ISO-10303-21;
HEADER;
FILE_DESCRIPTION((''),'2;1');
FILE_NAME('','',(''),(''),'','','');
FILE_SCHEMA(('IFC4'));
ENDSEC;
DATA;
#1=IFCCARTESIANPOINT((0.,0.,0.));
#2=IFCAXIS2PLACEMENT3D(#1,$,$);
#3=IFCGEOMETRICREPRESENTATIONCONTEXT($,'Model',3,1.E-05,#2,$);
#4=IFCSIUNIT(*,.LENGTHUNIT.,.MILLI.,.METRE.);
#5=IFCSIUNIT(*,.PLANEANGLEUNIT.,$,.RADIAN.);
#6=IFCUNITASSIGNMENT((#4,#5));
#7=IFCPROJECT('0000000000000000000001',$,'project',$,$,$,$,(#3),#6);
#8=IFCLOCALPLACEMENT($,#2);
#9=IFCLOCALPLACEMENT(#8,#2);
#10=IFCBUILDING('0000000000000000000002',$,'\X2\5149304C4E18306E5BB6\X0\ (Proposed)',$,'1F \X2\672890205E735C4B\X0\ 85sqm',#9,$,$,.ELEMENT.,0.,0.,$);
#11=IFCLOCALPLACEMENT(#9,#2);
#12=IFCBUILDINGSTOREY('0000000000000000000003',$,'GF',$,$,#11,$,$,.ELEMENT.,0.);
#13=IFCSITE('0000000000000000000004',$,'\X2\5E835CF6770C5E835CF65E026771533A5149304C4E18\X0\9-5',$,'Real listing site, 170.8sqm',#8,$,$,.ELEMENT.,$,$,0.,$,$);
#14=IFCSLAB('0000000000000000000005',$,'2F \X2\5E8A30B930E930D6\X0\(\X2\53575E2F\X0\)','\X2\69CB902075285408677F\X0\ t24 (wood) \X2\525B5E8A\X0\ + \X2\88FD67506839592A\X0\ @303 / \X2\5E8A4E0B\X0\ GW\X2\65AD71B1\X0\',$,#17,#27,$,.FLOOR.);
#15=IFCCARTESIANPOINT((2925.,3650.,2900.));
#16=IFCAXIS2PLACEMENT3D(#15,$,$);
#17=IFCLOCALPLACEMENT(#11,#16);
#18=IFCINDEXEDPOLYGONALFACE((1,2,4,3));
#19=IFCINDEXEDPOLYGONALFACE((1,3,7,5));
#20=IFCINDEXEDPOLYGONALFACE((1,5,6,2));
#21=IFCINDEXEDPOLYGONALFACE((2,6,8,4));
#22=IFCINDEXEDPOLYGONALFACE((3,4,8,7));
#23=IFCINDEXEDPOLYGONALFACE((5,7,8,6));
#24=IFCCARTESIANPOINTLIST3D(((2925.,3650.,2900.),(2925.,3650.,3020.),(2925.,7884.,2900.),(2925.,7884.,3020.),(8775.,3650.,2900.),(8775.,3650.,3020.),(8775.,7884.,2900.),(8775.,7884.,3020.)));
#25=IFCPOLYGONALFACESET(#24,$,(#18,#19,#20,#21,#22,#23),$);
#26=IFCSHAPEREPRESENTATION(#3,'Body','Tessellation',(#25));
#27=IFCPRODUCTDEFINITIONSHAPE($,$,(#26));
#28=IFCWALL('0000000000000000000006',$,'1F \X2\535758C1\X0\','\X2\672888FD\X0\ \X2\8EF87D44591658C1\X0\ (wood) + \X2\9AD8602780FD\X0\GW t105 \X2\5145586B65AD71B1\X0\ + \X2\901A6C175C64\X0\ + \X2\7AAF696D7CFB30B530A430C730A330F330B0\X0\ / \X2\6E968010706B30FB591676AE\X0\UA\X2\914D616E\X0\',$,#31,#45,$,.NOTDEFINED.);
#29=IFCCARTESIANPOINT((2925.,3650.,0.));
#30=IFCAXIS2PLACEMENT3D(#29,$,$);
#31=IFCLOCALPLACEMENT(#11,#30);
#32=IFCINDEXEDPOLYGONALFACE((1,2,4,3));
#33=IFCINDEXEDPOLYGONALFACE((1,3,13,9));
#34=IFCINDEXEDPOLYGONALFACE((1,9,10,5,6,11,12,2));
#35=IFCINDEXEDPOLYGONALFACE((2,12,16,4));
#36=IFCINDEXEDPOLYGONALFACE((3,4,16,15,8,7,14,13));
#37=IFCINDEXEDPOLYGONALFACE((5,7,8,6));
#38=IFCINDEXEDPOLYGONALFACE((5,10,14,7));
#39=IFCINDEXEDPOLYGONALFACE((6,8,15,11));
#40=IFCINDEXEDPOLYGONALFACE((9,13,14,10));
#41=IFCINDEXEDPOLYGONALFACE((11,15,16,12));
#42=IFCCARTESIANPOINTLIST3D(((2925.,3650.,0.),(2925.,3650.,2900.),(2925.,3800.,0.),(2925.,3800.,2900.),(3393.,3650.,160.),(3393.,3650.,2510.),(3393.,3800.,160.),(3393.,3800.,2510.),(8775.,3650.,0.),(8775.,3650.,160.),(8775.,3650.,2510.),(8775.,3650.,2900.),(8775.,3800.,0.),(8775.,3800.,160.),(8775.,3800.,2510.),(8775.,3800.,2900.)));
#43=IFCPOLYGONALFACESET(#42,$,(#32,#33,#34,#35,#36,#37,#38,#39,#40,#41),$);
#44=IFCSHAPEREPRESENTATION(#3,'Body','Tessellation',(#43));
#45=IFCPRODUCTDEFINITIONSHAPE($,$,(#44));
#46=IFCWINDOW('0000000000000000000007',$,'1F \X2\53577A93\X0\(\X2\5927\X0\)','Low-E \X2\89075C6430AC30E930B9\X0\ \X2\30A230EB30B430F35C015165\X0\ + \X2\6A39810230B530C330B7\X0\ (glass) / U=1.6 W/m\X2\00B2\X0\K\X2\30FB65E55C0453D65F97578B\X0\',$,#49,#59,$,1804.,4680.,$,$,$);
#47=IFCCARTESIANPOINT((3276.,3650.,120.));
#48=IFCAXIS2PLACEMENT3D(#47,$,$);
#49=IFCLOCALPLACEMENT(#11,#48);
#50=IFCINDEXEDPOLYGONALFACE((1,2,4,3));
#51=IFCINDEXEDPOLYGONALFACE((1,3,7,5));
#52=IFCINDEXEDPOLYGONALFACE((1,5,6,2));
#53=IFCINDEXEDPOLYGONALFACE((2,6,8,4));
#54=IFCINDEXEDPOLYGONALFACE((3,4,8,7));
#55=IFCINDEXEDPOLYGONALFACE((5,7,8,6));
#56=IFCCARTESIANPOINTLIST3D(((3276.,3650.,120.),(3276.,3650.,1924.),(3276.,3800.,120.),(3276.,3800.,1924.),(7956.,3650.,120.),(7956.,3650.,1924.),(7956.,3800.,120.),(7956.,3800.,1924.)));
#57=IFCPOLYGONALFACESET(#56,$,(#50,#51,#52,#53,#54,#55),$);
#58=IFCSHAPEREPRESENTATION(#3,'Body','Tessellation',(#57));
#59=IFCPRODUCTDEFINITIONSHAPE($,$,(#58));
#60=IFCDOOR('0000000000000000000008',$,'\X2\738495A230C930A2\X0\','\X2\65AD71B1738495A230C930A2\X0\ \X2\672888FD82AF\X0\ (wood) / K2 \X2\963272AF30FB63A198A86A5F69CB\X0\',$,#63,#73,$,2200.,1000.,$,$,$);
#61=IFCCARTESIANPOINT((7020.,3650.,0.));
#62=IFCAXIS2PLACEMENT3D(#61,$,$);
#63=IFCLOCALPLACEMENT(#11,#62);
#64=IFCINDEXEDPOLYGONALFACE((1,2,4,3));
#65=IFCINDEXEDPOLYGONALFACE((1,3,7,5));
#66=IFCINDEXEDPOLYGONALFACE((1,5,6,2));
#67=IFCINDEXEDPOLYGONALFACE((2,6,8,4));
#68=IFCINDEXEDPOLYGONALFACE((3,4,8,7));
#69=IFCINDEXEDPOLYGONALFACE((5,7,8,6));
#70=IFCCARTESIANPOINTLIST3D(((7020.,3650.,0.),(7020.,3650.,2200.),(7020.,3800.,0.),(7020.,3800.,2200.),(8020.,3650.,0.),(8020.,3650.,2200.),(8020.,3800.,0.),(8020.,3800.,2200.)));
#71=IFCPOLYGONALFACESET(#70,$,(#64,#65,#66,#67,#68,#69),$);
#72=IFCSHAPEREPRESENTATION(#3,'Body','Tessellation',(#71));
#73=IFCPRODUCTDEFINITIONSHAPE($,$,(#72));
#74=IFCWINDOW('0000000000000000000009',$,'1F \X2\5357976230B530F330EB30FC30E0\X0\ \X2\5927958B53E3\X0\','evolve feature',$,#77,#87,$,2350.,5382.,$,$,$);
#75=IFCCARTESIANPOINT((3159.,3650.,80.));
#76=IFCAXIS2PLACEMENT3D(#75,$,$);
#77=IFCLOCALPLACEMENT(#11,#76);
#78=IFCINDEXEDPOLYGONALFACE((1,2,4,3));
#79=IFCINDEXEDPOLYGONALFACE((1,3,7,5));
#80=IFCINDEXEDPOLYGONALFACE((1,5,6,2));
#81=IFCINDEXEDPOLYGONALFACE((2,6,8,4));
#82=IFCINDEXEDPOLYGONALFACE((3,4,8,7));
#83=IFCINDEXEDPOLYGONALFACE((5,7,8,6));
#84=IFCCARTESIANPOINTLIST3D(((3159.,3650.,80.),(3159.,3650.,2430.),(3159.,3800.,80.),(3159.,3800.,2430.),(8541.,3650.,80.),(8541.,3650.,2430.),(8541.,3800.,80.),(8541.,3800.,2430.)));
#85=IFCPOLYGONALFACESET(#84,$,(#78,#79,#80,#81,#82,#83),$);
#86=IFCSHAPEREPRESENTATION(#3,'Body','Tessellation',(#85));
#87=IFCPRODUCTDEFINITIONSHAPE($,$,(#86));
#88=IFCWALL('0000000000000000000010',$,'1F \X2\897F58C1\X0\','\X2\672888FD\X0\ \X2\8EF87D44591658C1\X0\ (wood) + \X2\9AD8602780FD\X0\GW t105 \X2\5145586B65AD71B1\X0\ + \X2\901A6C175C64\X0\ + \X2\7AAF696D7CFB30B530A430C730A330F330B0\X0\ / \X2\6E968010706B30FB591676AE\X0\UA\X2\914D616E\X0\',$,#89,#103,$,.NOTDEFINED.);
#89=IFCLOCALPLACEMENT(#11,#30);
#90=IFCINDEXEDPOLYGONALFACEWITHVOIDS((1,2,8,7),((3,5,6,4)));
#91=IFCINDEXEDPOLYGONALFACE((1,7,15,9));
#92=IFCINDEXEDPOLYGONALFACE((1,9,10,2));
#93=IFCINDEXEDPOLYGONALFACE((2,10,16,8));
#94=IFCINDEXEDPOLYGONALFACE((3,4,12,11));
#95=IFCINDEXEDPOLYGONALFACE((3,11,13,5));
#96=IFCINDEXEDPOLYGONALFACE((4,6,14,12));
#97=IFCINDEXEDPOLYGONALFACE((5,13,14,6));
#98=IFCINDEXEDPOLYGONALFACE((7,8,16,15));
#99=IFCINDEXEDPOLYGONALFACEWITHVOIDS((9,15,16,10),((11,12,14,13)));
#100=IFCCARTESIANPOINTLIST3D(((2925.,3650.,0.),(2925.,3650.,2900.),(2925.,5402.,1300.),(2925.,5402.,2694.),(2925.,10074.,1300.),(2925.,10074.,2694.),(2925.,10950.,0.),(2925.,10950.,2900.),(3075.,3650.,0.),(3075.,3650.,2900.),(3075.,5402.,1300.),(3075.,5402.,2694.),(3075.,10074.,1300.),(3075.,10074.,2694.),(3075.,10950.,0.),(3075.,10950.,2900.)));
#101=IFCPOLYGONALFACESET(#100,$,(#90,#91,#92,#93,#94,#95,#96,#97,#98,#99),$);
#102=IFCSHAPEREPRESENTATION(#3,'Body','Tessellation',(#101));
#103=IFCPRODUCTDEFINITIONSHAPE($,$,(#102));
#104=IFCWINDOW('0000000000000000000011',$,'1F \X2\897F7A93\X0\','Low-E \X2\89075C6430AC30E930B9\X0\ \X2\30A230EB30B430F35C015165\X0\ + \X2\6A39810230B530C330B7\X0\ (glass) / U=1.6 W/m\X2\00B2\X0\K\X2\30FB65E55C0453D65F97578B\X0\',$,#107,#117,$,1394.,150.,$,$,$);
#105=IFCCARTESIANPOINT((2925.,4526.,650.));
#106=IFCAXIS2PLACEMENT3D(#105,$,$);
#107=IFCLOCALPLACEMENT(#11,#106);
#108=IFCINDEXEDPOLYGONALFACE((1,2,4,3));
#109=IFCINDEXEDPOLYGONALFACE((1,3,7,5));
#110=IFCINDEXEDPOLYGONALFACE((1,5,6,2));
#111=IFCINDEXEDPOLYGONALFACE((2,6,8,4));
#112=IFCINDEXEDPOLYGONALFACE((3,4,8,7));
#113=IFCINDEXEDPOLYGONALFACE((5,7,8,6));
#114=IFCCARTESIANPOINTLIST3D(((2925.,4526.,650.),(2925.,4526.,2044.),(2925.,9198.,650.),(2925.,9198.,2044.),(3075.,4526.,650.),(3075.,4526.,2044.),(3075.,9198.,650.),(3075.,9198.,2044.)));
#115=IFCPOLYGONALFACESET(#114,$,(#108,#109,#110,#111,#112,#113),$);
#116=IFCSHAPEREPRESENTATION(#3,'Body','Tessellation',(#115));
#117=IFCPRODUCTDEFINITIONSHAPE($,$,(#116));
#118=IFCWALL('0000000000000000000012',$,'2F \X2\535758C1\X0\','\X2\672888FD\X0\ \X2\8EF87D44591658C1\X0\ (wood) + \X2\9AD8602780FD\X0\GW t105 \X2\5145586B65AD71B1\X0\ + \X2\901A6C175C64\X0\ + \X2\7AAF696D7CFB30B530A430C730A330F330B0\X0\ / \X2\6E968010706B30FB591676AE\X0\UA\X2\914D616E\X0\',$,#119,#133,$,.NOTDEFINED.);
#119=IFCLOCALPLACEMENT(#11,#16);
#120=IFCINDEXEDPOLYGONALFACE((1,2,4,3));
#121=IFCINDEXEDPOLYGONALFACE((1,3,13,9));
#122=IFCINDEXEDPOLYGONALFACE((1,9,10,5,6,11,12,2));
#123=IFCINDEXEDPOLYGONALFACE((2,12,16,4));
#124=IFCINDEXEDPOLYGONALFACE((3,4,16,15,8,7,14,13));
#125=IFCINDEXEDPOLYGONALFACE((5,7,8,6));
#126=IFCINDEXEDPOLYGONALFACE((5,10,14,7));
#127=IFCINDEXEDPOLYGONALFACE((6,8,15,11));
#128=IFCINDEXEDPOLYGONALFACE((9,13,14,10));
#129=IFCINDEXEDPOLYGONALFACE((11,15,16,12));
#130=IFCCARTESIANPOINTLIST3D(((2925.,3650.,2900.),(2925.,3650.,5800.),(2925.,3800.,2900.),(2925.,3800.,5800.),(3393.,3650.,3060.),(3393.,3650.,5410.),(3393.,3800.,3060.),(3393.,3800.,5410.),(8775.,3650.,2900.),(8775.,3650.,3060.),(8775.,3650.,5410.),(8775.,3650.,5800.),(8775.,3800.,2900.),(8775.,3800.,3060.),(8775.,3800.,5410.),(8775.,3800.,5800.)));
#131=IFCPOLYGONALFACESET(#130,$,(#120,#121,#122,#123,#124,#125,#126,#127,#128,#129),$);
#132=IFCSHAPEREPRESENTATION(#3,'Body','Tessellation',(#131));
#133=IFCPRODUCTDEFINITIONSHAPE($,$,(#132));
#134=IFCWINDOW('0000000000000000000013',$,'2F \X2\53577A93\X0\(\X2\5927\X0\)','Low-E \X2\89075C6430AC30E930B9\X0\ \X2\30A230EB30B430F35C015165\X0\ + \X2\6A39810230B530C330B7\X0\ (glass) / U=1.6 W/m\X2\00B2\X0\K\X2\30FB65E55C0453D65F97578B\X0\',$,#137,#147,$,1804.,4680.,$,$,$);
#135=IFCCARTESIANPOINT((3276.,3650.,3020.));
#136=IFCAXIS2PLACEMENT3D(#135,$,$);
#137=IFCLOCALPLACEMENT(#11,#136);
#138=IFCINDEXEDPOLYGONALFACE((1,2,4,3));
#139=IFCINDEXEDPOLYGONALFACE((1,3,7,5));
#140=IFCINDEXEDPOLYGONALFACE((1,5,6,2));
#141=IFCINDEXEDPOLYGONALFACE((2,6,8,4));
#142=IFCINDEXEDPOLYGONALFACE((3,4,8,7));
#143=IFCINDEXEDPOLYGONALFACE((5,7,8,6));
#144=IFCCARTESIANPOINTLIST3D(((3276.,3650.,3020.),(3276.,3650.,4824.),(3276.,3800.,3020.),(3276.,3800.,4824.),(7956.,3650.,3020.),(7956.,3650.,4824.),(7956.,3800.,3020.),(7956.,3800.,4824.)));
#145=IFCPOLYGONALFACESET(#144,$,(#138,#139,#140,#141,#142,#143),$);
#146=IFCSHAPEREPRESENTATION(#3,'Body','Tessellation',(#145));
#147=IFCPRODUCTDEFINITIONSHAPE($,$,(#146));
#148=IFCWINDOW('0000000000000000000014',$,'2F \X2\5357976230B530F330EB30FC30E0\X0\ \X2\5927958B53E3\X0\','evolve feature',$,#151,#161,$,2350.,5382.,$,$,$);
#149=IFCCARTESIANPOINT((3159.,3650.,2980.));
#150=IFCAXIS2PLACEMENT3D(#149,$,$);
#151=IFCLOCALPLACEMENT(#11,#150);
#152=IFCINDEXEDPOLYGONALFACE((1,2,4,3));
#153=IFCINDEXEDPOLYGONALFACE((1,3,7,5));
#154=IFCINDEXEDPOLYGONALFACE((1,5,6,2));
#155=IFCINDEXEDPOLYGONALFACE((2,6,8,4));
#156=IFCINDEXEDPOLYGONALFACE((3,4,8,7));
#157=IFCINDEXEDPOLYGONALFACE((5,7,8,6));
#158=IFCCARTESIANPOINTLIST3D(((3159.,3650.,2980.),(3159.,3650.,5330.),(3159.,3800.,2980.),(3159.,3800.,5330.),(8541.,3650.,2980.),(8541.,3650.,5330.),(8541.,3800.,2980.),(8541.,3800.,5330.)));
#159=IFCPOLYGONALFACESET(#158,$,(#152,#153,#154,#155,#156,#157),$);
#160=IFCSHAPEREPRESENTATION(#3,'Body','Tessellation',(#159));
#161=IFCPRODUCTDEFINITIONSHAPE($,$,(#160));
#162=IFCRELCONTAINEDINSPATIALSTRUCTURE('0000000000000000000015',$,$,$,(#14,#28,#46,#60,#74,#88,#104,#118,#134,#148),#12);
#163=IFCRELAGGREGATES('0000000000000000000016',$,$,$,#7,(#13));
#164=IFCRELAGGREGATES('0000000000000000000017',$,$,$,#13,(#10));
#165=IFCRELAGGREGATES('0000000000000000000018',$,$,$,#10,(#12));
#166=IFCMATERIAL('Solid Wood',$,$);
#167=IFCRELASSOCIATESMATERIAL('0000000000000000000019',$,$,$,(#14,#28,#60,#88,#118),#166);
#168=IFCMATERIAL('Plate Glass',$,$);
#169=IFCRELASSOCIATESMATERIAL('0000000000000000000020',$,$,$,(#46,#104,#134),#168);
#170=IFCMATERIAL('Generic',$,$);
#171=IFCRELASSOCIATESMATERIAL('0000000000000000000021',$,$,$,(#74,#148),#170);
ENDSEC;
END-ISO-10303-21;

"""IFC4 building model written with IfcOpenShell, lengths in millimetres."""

from ifc_helpers import new_model, si_unit, frame, frame_2d, origin, place, context, project, spatial, rectangle, extrude, material, element, fill, save


model = new_model("IFC4")

# Units and contexts
model_context = context("Model", 3, precision=1e-05, world=origin())
ifc_project = project(units=[si_unit("LENGTHUNIT", "METRE", prefix="MILLI"), si_unit("PLANEANGLEUNIT", "RADIAN")], contexts=[model_context])

# Site, building, storey
site_placement = place(None, origin())
site = spatial("IfcSite", under=ifc_project, at=site_placement, Name="広島県広島市東区光が丘9-5", ObjectType="Real listing site, 170.8sqm", CompositionType="ELEMENT", RefElevation=0.0)
building_placement = place(site_placement, origin())
building = spatial("IfcBuilding", under=site, at=building_placement, Name="光が丘の家 (Proposed)", ObjectType="1F 木造平屋 85sqm", CompositionType="ELEMENT", ElevationOfRefHeight=0.0, ElevationOfTerrain=0.0)
storey_placement = place(building_placement, origin())
storey = spatial("IfcBuildingStorey", under=building, at=storey_placement, Name="GF", CompositionType="ELEMENT", Elevation=0.0)

# Slab
ifc_material_1 = material(Name="Solid Wood")
slab_1_placement = place(storey_placement, frame((2925.0, 3650.0, 2900.0)))
element("IfcSlab", 1, at=slab_1_placement, inside=storey, material=ifc_material_1, Name="2F 床スラブ(南帯)", Description="構造用合板 t24 (wood) 剛床 + 製材根太 @303 / 床下 GW断熱", PredefinedType="FLOOR", context=model_context, shape_type="SweptSolid", body=[
    extrude(rectangle(XDim=5850.0, YDim=4234.0, at=frame_2d((2925.0, 2117.0))), frame((2925.0, 3650.0, 2900.0)), (0.0, 0.0, 1.0), 120.0),
])
ifc_material_2 = material(Name="Generic")

# Wall, openings, windows, door
wall_1_placement = place(storey_placement, frame((2925.0, 3650.0, 0.0)))
wall_1 = element("IfcWall", 2, at=wall_1_placement, inside=storey, material=ifc_material_1, Name="1F 南壁", Description="木製 軸組外壁 (wood) + 高性能GW t105 充填断熱 + 通気層 + 窯業系サイディング / 準耐火・外皮UA配慮", PredefinedType="NOTDEFINED", context=model_context, shape_type="SweptSolid", body=[
    extrude(rectangle(XDim=5850.0, YDim=150.0, at=frame_2d((2925.0, 75.0))), frame((2925.0, 3650.0, 0.0)), (0.0, 0.0, 1.0), 2900.0),
])
opening_1_placement = place(storey_placement, frame((3276.0, 3650.0, 120.0)))
opening_1 = element("IfcOpeningElement", 3, at=opening_1_placement, cuts=wall_1, PredefinedType="NOTDEFINED", context=model_context, shape_type="SweptSolid", body=[
    extrude(rectangle(XDim=4680.0, YDim=150.0, at=frame_2d((2340.0, 75.0))), frame((3276.0, 3650.0, 120.0)), (0.0, 0.0, 1.0), 1804.0),
])
opening_2_placement = place(storey_placement, frame((7020.0, 3650.0, 0.0)))
opening_2 = element("IfcOpeningElement", 4, at=opening_2_placement, cuts=wall_1, PredefinedType="NOTDEFINED", context=model_context, shape_type="SweptSolid", body=[
    extrude(rectangle(XDim=1000.0, YDim=150.0, at=frame_2d((500.0, 75.0))), frame((7020.0, 3650.0, 0.0)), (0.0, 0.0, 1.0), 2200.0),
])
opening_3_placement = place(storey_placement, frame((3159.0, 3650.0, 80.0)))
opening_3 = element("IfcOpeningElement", 5, at=opening_3_placement, cuts=wall_1, PredefinedType="NOTDEFINED", context=model_context, shape_type="SweptSolid", body=[
    extrude(rectangle(XDim=5382.0, YDim=150.0, at=frame_2d((2691.0, 75.0))), frame((3159.0, 3650.0, 80.0)), (0.0, 0.0, 1.0), 2350.0),
])
ifc_material_3 = material(Name="Plate Glass")
window_1_placement = place(storey_placement, frame((3276.0, 3650.0, 120.0)))
window_1 = element("IfcWindow", 6, at=window_1_placement, inside=storey, material=ifc_material_3, Name="1F 南窓(大)", Description="Low-E 複層ガラス アルゴン封入 + 樹脂サッシ (glass) / U=1.6 W/m²K・日射取得型", OverallHeight=1804.0, OverallWidth=4680.0, context=model_context, shape_type="SweptSolid", body=[
    extrude(rectangle(XDim=4680.0, YDim=150.0, at=frame_2d((2340.0, 75.0))), frame((3276.0, 3650.0, 120.0)), (0.0, 0.0, 1.0), 1804.0),
])
fill(opening_1, window_1)
door_placement = place(storey_placement, frame((7020.0, 3650.0, 0.0)))
door = element("IfcDoor", 7, at=door_placement, inside=storey, material=ifc_material_1, Name="玄関ドア", Description="断熱玄関ドア 木製芯 (wood) / K2 防犯・採風機構", OverallHeight=2200.0, OverallWidth=1000.0, context=model_context, shape_type="SweptSolid", body=[
    extrude(rectangle(XDim=1000.0, YDim=150.0, at=frame_2d((500.0, 75.0))), frame((7020.0, 3650.0, 0.0)), (0.0, 0.0, 1.0), 2200.0),
])
fill(opening_2, door)
window_2_placement = place(storey_placement, frame((3159.0, 3650.0, 80.0)))
window_2 = element("IfcWindow", 8, at=window_2_placement, inside=storey, material=ifc_material_2, Name="1F 南面サンルーム 大開口", Description="evolve feature", OverallHeight=2350.0, OverallWidth=5382.0, context=model_context, shape_type="SweptSolid", body=[
    extrude(rectangle(XDim=5382.0, YDim=150.0, at=frame_2d((2691.0, 75.0))), frame((3159.0, 3650.0, 80.0)), (0.0, 0.0, 1.0), 2350.0),
])
fill(opening_3, window_2)

# Wall, opening, window
wall_2_placement = place(storey_placement, frame((2925.0, 3650.0, 0.0)))
wall_2 = element("IfcWall", 9, at=wall_2_placement, inside=storey, material=ifc_material_1, Name="1F 西壁", Description="木製 軸組外壁 (wood) + 高性能GW t105 充填断熱 + 通気層 + 窯業系サイディング / 準耐火・外皮UA配慮", PredefinedType="NOTDEFINED", context=model_context, shape_type="SweptSolid", body=[
    extrude(rectangle(XDim=150.0, YDim=7300.0, at=frame_2d((75.0, 3650.0))), frame((2925.0, 3650.0, 0.0)), (0.0, 0.0, 1.0), 2900.0),
])
opening_4_placement = place(storey_placement, frame((2925.0, 4526.0, 650.0)))
opening_4 = element("IfcOpeningElement", 10, at=opening_4_placement, cuts=wall_2, PredefinedType="NOTDEFINED", context=model_context, shape_type="SweptSolid", body=[
    extrude(rectangle(XDim=150.0, YDim=4672.0, at=frame_2d((75.0, 2336.0))), frame((2925.0, 4526.0, 650.0)), (0.0, 0.0, 1.0), 1394.0),
])
window_3_placement = place(storey_placement, frame((2925.0, 4526.0, 650.0)))
window_3 = element("IfcWindow", 11, at=window_3_placement, inside=storey, material=ifc_material_3, Name="1F 西窓", Description="Low-E 複層ガラス アルゴン封入 + 樹脂サッシ (glass) / U=1.6 W/m²K・日射取得型", OverallHeight=1394.0, OverallWidth=150.0, context=model_context, shape_type="SweptSolid", body=[
    extrude(rectangle(XDim=150.0, YDim=4672.0, at=frame_2d((75.0, 2336.0))), frame((2925.0, 4526.0, 650.0)), (0.0, 0.0, 1.0), 1394.0),
])
fill(opening_4, window_3)

# Wall, openings, windows
wall_3_placement = place(storey_placement, frame((2925.0, 3650.0, 2900.0)))
wall_3 = element("IfcWall", 12, at=wall_3_placement, inside=storey, material=ifc_material_1, Name="2F 南壁", Description="木製 軸組外壁 (wood) + 高性能GW t105 充填断熱 + 通気層 + 窯業系サイディング / 準耐火・外皮UA配慮", PredefinedType="NOTDEFINED", context=model_context, shape_type="SweptSolid", body=[
    extrude(rectangle(XDim=5850.0, YDim=150.0, at=frame_2d((2925.0, 75.0))), frame((2925.0, 3650.0, 2900.0)), (0.0, 0.0, 1.0), 2900.0),
])
opening_5_placement = place(storey_placement, frame((3276.0, 3650.0, 3020.0)))
opening_5 = element("IfcOpeningElement", 13, at=opening_5_placement, cuts=wall_3, PredefinedType="NOTDEFINED", context=model_context, shape_type="SweptSolid", body=[
    extrude(rectangle(XDim=4680.0, YDim=150.0, at=frame_2d((2340.0, 75.0))), frame((3276.0, 3650.0, 3020.0)), (0.0, 0.0, 1.0), 1804.0),
])
opening_6_placement = place(storey_placement, frame((3159.0, 3650.0, 2980.0)))
opening_6 = element("IfcOpeningElement", 14, at=opening_6_placement, cuts=wall_3, PredefinedType="NOTDEFINED", context=model_context, shape_type="SweptSolid", body=[
    extrude(rectangle(XDim=5382.0, YDim=150.0, at=frame_2d((2691.0, 75.0))), frame((3159.0, 3650.0, 2980.0)), (0.0, 0.0, 1.0), 2350.0),
])
window_4_placement = place(storey_placement, frame((3276.0, 3650.0, 3020.0)))
window_4 = element("IfcWindow", 15, at=window_4_placement, inside=storey, material=ifc_material_3, Name="2F 南窓(大)", Description="Low-E 複層ガラス アルゴン封入 + 樹脂サッシ (glass) / U=1.6 W/m²K・日射取得型", OverallHeight=1804.0, OverallWidth=4680.0, context=model_context, shape_type="SweptSolid", body=[
    extrude(rectangle(XDim=4680.0, YDim=150.0, at=frame_2d((2340.0, 75.0))), frame((3276.0, 3650.0, 3020.0)), (0.0, 0.0, 1.0), 1804.0),
])
fill(opening_5, window_4)
window_5_placement = place(storey_placement, frame((3159.0, 3650.0, 2980.0)))
window_5 = element("IfcWindow", 16, at=window_5_placement, inside=storey, material=ifc_material_2, Name="2F 南面サンルーム 大開口", Description="evolve feature", OverallHeight=2350.0, OverallWidth=5382.0, context=model_context, shape_type="SweptSolid", body=[
    extrude(rectangle(XDim=5382.0, YDim=150.0, at=frame_2d((2691.0, 75.0))), frame((3159.0, 3650.0, 2980.0)), (0.0, 0.0, 1.0), 2350.0),
])
fill(opening_6, window_5)

save(model, "model.ifc")
